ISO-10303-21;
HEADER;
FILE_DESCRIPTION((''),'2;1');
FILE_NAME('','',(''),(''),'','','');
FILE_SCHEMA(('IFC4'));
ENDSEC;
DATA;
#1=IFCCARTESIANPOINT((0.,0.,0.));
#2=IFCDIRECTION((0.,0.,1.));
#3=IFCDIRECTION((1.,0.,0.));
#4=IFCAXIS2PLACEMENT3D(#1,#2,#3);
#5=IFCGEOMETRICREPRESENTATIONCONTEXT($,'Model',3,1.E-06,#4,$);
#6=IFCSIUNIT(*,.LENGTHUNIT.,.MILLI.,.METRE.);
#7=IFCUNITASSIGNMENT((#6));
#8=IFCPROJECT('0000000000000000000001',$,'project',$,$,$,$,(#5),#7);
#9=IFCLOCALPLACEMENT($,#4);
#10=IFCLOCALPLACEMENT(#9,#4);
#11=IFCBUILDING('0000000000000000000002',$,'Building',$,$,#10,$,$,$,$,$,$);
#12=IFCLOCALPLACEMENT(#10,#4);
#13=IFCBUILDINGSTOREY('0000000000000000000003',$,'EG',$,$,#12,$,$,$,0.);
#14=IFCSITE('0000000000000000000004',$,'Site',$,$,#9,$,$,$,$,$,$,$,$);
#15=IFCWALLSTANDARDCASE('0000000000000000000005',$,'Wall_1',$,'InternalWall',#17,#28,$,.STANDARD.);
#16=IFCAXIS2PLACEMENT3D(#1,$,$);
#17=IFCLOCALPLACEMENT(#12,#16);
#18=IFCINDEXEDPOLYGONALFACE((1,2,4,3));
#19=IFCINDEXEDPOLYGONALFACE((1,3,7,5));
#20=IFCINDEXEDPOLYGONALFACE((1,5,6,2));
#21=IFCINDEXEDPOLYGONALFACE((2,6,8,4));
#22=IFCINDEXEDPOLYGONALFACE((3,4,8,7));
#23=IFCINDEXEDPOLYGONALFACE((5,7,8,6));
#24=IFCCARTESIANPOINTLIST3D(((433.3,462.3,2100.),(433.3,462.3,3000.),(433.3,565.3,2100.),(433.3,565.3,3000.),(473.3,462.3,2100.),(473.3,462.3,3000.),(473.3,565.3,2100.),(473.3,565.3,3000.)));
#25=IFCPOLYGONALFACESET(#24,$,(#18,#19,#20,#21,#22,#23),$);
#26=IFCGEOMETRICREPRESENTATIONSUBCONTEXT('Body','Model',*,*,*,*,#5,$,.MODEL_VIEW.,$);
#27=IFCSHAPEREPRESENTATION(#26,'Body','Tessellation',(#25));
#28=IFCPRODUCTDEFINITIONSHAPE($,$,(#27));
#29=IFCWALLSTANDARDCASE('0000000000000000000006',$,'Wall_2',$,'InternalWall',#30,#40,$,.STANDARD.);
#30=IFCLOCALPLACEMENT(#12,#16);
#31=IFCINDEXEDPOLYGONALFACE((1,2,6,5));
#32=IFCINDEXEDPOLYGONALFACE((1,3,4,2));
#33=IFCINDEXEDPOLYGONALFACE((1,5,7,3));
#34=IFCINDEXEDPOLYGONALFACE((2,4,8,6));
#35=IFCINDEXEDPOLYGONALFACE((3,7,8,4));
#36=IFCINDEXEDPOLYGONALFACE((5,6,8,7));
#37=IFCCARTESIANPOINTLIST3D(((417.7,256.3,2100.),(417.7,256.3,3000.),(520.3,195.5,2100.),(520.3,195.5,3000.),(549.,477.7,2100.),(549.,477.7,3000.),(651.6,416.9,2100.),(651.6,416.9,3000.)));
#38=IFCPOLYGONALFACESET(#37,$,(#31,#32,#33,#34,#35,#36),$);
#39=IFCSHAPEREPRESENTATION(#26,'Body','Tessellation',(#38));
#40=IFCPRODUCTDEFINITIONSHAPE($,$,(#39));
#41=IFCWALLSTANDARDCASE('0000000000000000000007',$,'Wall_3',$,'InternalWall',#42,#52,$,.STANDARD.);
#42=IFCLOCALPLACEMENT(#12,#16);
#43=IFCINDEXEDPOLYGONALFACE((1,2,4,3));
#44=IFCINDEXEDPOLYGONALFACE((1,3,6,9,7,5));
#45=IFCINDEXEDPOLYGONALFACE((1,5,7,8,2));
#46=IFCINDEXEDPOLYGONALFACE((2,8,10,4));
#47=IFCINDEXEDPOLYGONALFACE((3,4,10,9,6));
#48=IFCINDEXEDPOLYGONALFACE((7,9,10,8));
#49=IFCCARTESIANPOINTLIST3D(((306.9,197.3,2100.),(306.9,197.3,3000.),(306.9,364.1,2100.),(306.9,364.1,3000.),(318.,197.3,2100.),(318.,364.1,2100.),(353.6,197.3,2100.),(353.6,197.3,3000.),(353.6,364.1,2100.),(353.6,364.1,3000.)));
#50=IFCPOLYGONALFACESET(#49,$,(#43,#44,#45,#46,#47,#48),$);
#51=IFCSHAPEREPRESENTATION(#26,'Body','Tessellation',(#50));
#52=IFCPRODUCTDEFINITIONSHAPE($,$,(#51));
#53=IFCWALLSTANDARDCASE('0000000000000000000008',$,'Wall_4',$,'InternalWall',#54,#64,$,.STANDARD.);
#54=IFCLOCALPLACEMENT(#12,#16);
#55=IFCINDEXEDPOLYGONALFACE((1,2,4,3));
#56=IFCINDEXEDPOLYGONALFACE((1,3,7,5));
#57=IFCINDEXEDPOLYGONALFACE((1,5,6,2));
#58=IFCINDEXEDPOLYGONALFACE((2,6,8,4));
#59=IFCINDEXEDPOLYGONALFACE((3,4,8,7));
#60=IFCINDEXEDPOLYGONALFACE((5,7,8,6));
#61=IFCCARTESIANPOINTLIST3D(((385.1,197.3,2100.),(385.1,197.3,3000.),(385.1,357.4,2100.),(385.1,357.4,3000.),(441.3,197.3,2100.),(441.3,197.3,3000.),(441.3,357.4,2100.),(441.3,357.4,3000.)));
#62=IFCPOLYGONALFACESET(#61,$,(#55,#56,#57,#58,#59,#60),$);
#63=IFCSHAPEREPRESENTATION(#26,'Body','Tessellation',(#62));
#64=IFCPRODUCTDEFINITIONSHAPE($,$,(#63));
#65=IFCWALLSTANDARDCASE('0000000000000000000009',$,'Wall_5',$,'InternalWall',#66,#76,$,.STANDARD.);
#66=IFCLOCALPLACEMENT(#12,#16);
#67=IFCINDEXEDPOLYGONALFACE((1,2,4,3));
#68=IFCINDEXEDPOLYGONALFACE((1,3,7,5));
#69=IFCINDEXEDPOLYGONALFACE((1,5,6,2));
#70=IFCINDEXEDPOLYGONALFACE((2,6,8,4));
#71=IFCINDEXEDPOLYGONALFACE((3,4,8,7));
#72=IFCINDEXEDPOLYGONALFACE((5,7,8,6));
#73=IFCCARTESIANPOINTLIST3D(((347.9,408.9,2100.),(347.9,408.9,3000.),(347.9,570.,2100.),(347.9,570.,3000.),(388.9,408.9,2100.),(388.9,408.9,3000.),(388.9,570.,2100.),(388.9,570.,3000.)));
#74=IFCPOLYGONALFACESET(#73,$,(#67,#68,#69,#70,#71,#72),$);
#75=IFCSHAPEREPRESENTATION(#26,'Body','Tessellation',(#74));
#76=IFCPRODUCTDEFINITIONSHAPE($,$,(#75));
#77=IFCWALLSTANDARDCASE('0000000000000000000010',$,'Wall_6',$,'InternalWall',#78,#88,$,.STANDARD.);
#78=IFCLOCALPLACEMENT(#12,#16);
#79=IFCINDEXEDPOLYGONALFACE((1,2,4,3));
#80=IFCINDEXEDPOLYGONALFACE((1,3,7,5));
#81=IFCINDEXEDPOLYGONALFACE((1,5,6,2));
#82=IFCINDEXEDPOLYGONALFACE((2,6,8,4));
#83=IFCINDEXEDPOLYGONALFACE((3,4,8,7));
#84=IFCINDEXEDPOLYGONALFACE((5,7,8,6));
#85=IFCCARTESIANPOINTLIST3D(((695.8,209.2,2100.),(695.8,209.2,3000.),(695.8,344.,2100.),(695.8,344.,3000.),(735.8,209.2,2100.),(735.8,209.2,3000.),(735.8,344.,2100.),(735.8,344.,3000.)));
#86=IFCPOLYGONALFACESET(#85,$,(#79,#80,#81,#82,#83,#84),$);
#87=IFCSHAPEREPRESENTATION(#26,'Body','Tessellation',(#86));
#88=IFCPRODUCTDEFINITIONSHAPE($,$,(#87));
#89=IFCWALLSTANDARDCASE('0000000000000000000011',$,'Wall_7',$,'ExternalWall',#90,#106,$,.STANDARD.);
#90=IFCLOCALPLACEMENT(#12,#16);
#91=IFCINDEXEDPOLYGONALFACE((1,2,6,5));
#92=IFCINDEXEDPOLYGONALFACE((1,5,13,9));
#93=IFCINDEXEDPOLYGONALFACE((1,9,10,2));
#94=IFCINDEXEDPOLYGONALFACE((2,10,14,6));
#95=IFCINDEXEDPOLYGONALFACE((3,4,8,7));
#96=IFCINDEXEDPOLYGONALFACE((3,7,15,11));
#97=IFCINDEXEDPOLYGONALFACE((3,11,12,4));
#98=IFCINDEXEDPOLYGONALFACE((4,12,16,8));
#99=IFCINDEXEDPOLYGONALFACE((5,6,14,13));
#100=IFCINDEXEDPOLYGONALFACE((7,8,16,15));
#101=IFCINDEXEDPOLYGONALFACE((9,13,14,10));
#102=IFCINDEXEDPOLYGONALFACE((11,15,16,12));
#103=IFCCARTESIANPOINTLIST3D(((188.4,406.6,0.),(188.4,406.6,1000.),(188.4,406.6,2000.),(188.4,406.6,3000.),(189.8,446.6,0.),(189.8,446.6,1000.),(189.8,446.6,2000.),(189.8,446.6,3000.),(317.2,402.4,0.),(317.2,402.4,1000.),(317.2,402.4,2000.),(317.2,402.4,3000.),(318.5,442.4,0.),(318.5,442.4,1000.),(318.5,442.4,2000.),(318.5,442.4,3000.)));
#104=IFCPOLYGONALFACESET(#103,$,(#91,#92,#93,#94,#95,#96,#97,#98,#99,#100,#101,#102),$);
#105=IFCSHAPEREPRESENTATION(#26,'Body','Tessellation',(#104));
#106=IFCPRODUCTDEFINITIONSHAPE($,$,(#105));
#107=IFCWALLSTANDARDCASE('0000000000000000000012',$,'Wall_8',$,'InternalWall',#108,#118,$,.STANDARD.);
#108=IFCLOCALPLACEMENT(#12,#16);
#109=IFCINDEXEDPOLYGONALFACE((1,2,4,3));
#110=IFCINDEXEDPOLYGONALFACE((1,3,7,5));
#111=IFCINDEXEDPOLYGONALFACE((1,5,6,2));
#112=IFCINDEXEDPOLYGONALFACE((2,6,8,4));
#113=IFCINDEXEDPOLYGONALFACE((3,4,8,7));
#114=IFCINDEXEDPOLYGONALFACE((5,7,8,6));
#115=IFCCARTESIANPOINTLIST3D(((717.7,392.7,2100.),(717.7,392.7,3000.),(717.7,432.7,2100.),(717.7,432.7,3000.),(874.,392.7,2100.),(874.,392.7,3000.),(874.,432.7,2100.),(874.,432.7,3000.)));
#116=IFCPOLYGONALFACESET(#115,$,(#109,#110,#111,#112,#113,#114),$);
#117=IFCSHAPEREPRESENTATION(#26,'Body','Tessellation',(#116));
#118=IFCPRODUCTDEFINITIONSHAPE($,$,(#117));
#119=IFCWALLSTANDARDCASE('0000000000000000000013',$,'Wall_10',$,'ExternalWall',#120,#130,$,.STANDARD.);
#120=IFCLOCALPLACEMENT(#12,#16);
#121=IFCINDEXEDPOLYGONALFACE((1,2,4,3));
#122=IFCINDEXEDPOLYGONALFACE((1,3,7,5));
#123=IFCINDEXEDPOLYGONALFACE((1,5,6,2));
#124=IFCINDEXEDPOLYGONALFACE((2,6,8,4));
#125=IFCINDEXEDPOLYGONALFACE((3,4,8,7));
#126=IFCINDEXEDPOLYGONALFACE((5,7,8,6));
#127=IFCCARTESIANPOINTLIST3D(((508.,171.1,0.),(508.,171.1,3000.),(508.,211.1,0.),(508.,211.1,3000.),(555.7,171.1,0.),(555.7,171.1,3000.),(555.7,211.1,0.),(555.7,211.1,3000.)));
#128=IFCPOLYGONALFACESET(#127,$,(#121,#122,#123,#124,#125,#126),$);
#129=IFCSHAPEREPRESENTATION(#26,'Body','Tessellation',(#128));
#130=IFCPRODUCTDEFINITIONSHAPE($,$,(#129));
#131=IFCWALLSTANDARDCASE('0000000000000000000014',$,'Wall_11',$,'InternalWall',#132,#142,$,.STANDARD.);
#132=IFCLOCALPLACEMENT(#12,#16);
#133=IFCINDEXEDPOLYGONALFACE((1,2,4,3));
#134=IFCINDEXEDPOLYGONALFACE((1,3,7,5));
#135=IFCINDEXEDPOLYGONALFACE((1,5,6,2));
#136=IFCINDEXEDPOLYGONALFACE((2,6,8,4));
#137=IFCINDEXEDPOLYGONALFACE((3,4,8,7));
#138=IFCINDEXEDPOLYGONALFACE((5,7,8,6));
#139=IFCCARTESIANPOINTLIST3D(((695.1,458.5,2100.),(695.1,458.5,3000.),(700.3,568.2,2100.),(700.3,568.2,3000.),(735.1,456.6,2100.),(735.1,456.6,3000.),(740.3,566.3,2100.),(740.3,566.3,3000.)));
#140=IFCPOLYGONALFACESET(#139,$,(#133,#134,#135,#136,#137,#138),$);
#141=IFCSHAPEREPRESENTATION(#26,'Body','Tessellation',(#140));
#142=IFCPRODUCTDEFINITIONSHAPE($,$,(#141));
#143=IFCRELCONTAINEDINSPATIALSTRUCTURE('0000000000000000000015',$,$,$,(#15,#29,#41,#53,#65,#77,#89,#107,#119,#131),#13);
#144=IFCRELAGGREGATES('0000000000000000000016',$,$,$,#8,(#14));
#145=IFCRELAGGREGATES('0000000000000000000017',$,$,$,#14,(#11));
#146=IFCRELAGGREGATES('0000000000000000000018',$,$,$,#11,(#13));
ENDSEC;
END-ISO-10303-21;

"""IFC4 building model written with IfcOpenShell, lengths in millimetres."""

from ifc_helpers import new_model, si_unit, frame, origin_with_axes, place, context, subcontext, project, spatial, rectangle, extrude, element, save


model = new_model("IFC4")

# Units and contexts
model_context = context("Model", 3, precision=1e-06, world=origin_with_axes())
body_context = subcontext(model_context, "Body", "Model", "MODEL_VIEW")
ifc_project = project(units=[si_unit("LENGTHUNIT", "METRE", prefix="MILLI")], contexts=[model_context])

# Site, building, storey
site_placement = place(None, origin_with_axes())
site = spatial("IfcSite", under=ifc_project, at=site_placement, Name="Site")
building_placement = place(site_placement, origin_with_axes())
building = spatial("IfcBuilding", under=site, at=building_placement, Name="Building")
storey_placement = place(building_placement, origin_with_axes())
storey = spatial("IfcBuildingStorey", under=building, at=storey_placement, Name="EG", Elevation=0.0)

# Wall, openings
wall_1_placement = place(storey_placement, origin_with_axes())
wall_1 = element("IfcWallStandardCase", 1, at=wall_1_placement, inside=storey, Name="Wall_1", ObjectType="InternalWall", PredefinedType="STANDARD", context=body_context, shape_type="SweptSolid", body=[
    extrude(rectangle(XDim=103.0, YDim=40.0), frame((453.3, 513.8, 0.0), z_axis=(0.0, 0.0, 1.0), x_axis=(0.0, 1.0, 0.0)), (0.0, 0.0, 1.0), 3000.0),
])
opening_1_placement = place(wall_1_placement, origin_with_axes())
element("IfcOpeningElement", 2, at=opening_1_placement, inside=storey, cuts=wall_1, context=body_context, shape_type="SweptSolid", body=[
    extrude(rectangle(XDim=450.0, YDim=40.0), frame((453.3, 481.3, 0.0), z_axis=(0.0, 0.0, 1.0), x_axis=(0.0, 1.0, 0.0)), (0.0, 0.0, 1.0), 2100.0),
])
opening_2_placement = place(wall_1_placement, origin_with_axes())
element("IfcOpeningElement", 3, at=opening_2_placement, inside=storey, cuts=wall_1, context=body_context, shape_type="SweptSolid", body=[
    extrude(rectangle(XDim=900.0, YDim=40.0), frame((403.6, 423.9, 0.0), z_axis=(0.0, 0.0, 1.0), x_axis=(0.0, 1.0, 0.0)), (0.0, 0.0, 1.0), 2100.0),
])

# Wall, opening
wall_2_placement = place(storey_placement, origin_with_axes())
wall_2 = element("IfcWallStandardCase", 4, at=wall_2_placement, inside=storey, Name="Wall_2", ObjectType="InternalWall", PredefinedType="STANDARD", context=body_context, shape_type="SweptSolid", body=[
    extrude(rectangle(XDim=257.4, YDim=119.2), frame((534.7, 336.6, 0.0), z_axis=(0.0, 0.0, 1.0), x_axis=(-0.510011, -0.860168, 0.0)), (0.0, 0.0, 1.0), 3000.0),
])
opening_3_placement = place(wall_2_placement, origin_with_axes())
element("IfcOpeningElement", 5, at=opening_3_placement, inside=storey, cuts=wall_2, context=body_context, shape_type="SweptSolid", body=[
    extrude(rectangle(XDim=450.0, YDim=119.2), frame((549.1, 360.9, 0.0), z_axis=(0.0, 0.0, 1.0), x_axis=(-0.510011, -0.860168, 0.0)), (0.0, 0.0, 1.0), 2100.0),
])

# Wall, openings
wall_3_placement = place(storey_placement, origin_with_axes())
wall_3 = element("IfcWallStandardCase", 6, at=wall_3_placement, inside=storey, Name="Wall_3", ObjectType="InternalWall", PredefinedType="STANDARD", context=body_context, shape_type="SweptSolid", body=[
    extrude(rectangle(XDim=166.8, YDim=46.7), frame((330.3, 280.7, 0.0), z_axis=(0.0, 0.0, 1.0), x_axis=(0.0, 1.0, 0.0)), (0.0, 0.0, 1.0), 3000.0),
])
opening_4_placement = place(wall_3_placement, origin_with_axes())
element("IfcOpeningElement", 7, at=opening_4_placement, inside=storey, cuts=wall_3, context=body_context, shape_type="SweptSolid", body=[
    extrude(rectangle(XDim=450.0, YDim=46.7), frame((330.3, 337.4, 0.0), z_axis=(0.0, 0.0, 1.0), x_axis=(0.0, 1.0, 0.0)), (0.0, 0.0, 1.0), 2100.0),
])
opening_5_placement = place(wall_3_placement, origin_with_axes())
element("IfcOpeningElement", 8, at=opening_5_placement, inside=storey, cuts=wall_3, context=body_context, shape_type="SweptSolid", body=[
    extrude(rectangle(XDim=900.0, YDim=46.7), frame((294.6, 386.3, 0.0), z_axis=(0.0, 0.0, 1.0), x_axis=(0.0, 1.0, 0.0)), (0.0, 0.0, 1.0), 2100.0),
])

# Walls, openings
wall_4_placement = place(storey_placement, origin_with_axes())
wall_4 = element("IfcWallStandardCase", 9, at=wall_4_placement, inside=storey, Name="Wall_4", ObjectType="InternalWall", PredefinedType="STANDARD", context=body_context, shape_type="SweptSolid", body=[
    extrude(rectangle(XDim=160.1, YDim=56.2), frame((413.2, 277.4, 0.0), z_axis=(0.0, 0.0, 1.0), x_axis=(0.0, 1.0, 0.0)), (0.0, 0.0, 1.0), 3000.0),
])
opening_6_placement = place(wall_4_placement, origin_with_axes())
element("IfcOpeningElement", 10, at=opening_6_placement, inside=storey, cuts=wall_4, context=body_context, shape_type="SweptSolid", body=[
    extrude(rectangle(XDim=450.0, YDim=56.2), frame((413.2, 335.5, 0.0), z_axis=(0.0, 0.0, 1.0), x_axis=(0.0, 1.0, 0.0)), (0.0, 0.0, 1.0), 2100.0),
])
wall_5_placement = place(storey_placement, origin_with_axes())
wall_5 = element("IfcWallStandardCase", 11, at=wall_5_placement, inside=storey, Name="Wall_5", ObjectType="InternalWall", PredefinedType="STANDARD", context=body_context, shape_type="SweptSolid", body=[
    extrude(rectangle(XDim=161.1, YDim=41.0), frame((368.4, 489.4, 0.0), z_axis=(0.0, 0.0, 1.0), x_axis=(0.0, 1.0, 0.0)), (0.0, 0.0, 1.0), 3000.0),
])
opening_7_placement = place(wall_5_placement, origin_with_axes())
element("IfcOpeningElement", 12, at=opening_7_placement, inside=storey, cuts=wall_5, context=body_context, shape_type="SweptSolid", body=[
    extrude(rectangle(XDim=450.0, YDim=41.0), frame((368.4, 428.9, 0.0), z_axis=(0.0, 0.0, 1.0), x_axis=(0.0, 1.0, 0.0)), (0.0, 0.0, 1.0), 2100.0),
])
wall_6_placement = place(storey_placement, origin_with_axes())
wall_6 = element("IfcWallStandardCase", 13, at=wall_6_placement, inside=storey, Name="Wall_6", ObjectType="InternalWall", PredefinedType="STANDARD", context=body_context, shape_type="SweptSolid", body=[
    extrude(rectangle(XDim=134.8, YDim=40.0), frame((715.8, 276.6, 0.0), z_axis=(0.0, 0.0, 1.0), x_axis=(0.0, -1.0, 0.0)), (0.0, 0.0, 1.0), 3000.0),
])
opening_8_placement = place(wall_6_placement, origin_with_axes())
element("IfcOpeningElement", 14, at=opening_8_placement, inside=storey, cuts=wall_6, context=body_context, shape_type="SweptSolid", body=[
    extrude(rectangle(XDim=450.0, YDim=40.0), frame((715.8, 330.2, 0.0), z_axis=(0.0, 0.0, 1.0), x_axis=(0.0, -1.0, 0.0)), (0.0, 0.0, 1.0), 2100.0),
])
wall_7_placement = place(storey_placement, origin_with_axes())
wall_7 = element("IfcWallStandardCase", 15, at=wall_7_placement, inside=storey, Name="Wall_7", ObjectType="ExternalWall", PredefinedType="STANDARD", context=body_context, shape_type="SweptSolid", body=[
    extrude(rectangle(XDim=128.8, YDim=40.0), frame((253.5, 424.5, 0.0), z_axis=(0.0, 0.0, 1.0), x_axis=(0.999454, -0.03304, 0.0)), (0.0, 0.0, 1.0), 3000.0),
])
opening_9_placement = place(wall_7_placement, origin_with_axes())
element("IfcOpeningElement", 16, at=opening_9_placement, inside=storey, cuts=wall_7, context=body_context, shape_type="SweptSolid", body=[
    extrude(rectangle(XDim=600.0, YDim=40.0), frame((194.3, 426.5, 1000.0), z_axis=(0.0, 0.0, 1.0), x_axis=(0.999454, -0.03304, 0.0)), (0.0, 0.0, 1.0), 1000.0),
])

# Wall, openings
wall_8_placement = place(storey_placement, origin_with_axes())
wall_8 = element("IfcWallStandardCase", 17, at=wall_8_placement, inside=storey, Name="Wall_8", ObjectType="InternalWall", PredefinedType="STANDARD", context=body_context, shape_type="SweptSolid", body=[
    extrude(rectangle(XDim=156.3, YDim=40.0), frame((795.9, 412.7, 0.0), z_axis=(0.0, 0.0, 1.0), x_axis=(-1.0, 0.0, 0.0)), (0.0, 0.0, 1.0), 3000.0),
])
opening_10_placement = place(wall_8_placement, origin_with_axes())
element("IfcOpeningElement", 18, at=opening_10_placement, inside=storey, cuts=wall_8, context=body_context, shape_type="SweptSolid", body=[
    extrude(rectangle(XDim=450.0, YDim=40.0), frame((738.2, 412.7, 0.0), z_axis=(0.0, 0.0, 1.0), x_axis=(-1.0, 0.0, 0.0)), (0.0, 0.0, 1.0), 2100.0),
])
opening_11_placement = place(wall_8_placement, origin_with_axes())
element("IfcOpeningElement", 19, at=opening_11_placement, inside=storey, cuts=wall_8, context=body_context, shape_type="SweptSolid", body=[
    extrude(rectangle(XDim=450.0, YDim=40.0), frame((733.9, 412.7, 0.0), z_axis=(0.0, 0.0, 1.0), x_axis=(-1.0, 0.0, 0.0)), (0.0, 0.0, 1.0), 2100.0),
])

# Wall
wall_9_placement = place(storey_placement, origin_with_axes())
element("IfcWallStandardCase", 20, at=wall_9_placement, inside=storey, Name="Wall_10", ObjectType="ExternalWall", PredefinedType="STANDARD", context=body_context, shape_type="SweptSolid", body=[
    extrude(rectangle(XDim=47.7, YDim=40.0), frame((531.8, 191.1, 0.0), z_axis=(0.0, 0.0, 1.0), x_axis=(-1.0, 0.0, 0.0)), (0.0, 0.0, 1.0), 3000.0),
])

# Wall, opening
wall_10_placement = place(storey_placement, origin_with_axes())
wall_10 = element("IfcWallStandardCase", 21, at=wall_10_placement, inside=storey, Name="Wall_11", ObjectType="InternalWall", PredefinedType="STANDARD", context=body_context, shape_type="SweptSolid", body=[
    extrude(rectangle(XDim=109.8, YDim=40.0), frame((717.7, 512.4, 0.0), z_axis=(0.0, 0.0, 1.0), x_axis=(-0.047565, -0.998868, 0.0)), (0.0, 0.0, 1.0), 3000.0),
])
opening_12_placement = place(wall_10_placement, origin_with_axes())
element("IfcOpeningElement", 22, at=opening_12_placement, inside=storey, cuts=wall_10, context=body_context, shape_type="SweptSolid", body=[
    extrude(rectangle(XDim=450.0, YDim=40.0), frame((716.1, 478.6, 0.0), z_axis=(0.0, 0.0, 1.0), x_axis=(-0.047565, -0.998868, 0.0)), (0.0, 0.0, 1.0), 2100.0),
])

save(model, "model.ifc")
